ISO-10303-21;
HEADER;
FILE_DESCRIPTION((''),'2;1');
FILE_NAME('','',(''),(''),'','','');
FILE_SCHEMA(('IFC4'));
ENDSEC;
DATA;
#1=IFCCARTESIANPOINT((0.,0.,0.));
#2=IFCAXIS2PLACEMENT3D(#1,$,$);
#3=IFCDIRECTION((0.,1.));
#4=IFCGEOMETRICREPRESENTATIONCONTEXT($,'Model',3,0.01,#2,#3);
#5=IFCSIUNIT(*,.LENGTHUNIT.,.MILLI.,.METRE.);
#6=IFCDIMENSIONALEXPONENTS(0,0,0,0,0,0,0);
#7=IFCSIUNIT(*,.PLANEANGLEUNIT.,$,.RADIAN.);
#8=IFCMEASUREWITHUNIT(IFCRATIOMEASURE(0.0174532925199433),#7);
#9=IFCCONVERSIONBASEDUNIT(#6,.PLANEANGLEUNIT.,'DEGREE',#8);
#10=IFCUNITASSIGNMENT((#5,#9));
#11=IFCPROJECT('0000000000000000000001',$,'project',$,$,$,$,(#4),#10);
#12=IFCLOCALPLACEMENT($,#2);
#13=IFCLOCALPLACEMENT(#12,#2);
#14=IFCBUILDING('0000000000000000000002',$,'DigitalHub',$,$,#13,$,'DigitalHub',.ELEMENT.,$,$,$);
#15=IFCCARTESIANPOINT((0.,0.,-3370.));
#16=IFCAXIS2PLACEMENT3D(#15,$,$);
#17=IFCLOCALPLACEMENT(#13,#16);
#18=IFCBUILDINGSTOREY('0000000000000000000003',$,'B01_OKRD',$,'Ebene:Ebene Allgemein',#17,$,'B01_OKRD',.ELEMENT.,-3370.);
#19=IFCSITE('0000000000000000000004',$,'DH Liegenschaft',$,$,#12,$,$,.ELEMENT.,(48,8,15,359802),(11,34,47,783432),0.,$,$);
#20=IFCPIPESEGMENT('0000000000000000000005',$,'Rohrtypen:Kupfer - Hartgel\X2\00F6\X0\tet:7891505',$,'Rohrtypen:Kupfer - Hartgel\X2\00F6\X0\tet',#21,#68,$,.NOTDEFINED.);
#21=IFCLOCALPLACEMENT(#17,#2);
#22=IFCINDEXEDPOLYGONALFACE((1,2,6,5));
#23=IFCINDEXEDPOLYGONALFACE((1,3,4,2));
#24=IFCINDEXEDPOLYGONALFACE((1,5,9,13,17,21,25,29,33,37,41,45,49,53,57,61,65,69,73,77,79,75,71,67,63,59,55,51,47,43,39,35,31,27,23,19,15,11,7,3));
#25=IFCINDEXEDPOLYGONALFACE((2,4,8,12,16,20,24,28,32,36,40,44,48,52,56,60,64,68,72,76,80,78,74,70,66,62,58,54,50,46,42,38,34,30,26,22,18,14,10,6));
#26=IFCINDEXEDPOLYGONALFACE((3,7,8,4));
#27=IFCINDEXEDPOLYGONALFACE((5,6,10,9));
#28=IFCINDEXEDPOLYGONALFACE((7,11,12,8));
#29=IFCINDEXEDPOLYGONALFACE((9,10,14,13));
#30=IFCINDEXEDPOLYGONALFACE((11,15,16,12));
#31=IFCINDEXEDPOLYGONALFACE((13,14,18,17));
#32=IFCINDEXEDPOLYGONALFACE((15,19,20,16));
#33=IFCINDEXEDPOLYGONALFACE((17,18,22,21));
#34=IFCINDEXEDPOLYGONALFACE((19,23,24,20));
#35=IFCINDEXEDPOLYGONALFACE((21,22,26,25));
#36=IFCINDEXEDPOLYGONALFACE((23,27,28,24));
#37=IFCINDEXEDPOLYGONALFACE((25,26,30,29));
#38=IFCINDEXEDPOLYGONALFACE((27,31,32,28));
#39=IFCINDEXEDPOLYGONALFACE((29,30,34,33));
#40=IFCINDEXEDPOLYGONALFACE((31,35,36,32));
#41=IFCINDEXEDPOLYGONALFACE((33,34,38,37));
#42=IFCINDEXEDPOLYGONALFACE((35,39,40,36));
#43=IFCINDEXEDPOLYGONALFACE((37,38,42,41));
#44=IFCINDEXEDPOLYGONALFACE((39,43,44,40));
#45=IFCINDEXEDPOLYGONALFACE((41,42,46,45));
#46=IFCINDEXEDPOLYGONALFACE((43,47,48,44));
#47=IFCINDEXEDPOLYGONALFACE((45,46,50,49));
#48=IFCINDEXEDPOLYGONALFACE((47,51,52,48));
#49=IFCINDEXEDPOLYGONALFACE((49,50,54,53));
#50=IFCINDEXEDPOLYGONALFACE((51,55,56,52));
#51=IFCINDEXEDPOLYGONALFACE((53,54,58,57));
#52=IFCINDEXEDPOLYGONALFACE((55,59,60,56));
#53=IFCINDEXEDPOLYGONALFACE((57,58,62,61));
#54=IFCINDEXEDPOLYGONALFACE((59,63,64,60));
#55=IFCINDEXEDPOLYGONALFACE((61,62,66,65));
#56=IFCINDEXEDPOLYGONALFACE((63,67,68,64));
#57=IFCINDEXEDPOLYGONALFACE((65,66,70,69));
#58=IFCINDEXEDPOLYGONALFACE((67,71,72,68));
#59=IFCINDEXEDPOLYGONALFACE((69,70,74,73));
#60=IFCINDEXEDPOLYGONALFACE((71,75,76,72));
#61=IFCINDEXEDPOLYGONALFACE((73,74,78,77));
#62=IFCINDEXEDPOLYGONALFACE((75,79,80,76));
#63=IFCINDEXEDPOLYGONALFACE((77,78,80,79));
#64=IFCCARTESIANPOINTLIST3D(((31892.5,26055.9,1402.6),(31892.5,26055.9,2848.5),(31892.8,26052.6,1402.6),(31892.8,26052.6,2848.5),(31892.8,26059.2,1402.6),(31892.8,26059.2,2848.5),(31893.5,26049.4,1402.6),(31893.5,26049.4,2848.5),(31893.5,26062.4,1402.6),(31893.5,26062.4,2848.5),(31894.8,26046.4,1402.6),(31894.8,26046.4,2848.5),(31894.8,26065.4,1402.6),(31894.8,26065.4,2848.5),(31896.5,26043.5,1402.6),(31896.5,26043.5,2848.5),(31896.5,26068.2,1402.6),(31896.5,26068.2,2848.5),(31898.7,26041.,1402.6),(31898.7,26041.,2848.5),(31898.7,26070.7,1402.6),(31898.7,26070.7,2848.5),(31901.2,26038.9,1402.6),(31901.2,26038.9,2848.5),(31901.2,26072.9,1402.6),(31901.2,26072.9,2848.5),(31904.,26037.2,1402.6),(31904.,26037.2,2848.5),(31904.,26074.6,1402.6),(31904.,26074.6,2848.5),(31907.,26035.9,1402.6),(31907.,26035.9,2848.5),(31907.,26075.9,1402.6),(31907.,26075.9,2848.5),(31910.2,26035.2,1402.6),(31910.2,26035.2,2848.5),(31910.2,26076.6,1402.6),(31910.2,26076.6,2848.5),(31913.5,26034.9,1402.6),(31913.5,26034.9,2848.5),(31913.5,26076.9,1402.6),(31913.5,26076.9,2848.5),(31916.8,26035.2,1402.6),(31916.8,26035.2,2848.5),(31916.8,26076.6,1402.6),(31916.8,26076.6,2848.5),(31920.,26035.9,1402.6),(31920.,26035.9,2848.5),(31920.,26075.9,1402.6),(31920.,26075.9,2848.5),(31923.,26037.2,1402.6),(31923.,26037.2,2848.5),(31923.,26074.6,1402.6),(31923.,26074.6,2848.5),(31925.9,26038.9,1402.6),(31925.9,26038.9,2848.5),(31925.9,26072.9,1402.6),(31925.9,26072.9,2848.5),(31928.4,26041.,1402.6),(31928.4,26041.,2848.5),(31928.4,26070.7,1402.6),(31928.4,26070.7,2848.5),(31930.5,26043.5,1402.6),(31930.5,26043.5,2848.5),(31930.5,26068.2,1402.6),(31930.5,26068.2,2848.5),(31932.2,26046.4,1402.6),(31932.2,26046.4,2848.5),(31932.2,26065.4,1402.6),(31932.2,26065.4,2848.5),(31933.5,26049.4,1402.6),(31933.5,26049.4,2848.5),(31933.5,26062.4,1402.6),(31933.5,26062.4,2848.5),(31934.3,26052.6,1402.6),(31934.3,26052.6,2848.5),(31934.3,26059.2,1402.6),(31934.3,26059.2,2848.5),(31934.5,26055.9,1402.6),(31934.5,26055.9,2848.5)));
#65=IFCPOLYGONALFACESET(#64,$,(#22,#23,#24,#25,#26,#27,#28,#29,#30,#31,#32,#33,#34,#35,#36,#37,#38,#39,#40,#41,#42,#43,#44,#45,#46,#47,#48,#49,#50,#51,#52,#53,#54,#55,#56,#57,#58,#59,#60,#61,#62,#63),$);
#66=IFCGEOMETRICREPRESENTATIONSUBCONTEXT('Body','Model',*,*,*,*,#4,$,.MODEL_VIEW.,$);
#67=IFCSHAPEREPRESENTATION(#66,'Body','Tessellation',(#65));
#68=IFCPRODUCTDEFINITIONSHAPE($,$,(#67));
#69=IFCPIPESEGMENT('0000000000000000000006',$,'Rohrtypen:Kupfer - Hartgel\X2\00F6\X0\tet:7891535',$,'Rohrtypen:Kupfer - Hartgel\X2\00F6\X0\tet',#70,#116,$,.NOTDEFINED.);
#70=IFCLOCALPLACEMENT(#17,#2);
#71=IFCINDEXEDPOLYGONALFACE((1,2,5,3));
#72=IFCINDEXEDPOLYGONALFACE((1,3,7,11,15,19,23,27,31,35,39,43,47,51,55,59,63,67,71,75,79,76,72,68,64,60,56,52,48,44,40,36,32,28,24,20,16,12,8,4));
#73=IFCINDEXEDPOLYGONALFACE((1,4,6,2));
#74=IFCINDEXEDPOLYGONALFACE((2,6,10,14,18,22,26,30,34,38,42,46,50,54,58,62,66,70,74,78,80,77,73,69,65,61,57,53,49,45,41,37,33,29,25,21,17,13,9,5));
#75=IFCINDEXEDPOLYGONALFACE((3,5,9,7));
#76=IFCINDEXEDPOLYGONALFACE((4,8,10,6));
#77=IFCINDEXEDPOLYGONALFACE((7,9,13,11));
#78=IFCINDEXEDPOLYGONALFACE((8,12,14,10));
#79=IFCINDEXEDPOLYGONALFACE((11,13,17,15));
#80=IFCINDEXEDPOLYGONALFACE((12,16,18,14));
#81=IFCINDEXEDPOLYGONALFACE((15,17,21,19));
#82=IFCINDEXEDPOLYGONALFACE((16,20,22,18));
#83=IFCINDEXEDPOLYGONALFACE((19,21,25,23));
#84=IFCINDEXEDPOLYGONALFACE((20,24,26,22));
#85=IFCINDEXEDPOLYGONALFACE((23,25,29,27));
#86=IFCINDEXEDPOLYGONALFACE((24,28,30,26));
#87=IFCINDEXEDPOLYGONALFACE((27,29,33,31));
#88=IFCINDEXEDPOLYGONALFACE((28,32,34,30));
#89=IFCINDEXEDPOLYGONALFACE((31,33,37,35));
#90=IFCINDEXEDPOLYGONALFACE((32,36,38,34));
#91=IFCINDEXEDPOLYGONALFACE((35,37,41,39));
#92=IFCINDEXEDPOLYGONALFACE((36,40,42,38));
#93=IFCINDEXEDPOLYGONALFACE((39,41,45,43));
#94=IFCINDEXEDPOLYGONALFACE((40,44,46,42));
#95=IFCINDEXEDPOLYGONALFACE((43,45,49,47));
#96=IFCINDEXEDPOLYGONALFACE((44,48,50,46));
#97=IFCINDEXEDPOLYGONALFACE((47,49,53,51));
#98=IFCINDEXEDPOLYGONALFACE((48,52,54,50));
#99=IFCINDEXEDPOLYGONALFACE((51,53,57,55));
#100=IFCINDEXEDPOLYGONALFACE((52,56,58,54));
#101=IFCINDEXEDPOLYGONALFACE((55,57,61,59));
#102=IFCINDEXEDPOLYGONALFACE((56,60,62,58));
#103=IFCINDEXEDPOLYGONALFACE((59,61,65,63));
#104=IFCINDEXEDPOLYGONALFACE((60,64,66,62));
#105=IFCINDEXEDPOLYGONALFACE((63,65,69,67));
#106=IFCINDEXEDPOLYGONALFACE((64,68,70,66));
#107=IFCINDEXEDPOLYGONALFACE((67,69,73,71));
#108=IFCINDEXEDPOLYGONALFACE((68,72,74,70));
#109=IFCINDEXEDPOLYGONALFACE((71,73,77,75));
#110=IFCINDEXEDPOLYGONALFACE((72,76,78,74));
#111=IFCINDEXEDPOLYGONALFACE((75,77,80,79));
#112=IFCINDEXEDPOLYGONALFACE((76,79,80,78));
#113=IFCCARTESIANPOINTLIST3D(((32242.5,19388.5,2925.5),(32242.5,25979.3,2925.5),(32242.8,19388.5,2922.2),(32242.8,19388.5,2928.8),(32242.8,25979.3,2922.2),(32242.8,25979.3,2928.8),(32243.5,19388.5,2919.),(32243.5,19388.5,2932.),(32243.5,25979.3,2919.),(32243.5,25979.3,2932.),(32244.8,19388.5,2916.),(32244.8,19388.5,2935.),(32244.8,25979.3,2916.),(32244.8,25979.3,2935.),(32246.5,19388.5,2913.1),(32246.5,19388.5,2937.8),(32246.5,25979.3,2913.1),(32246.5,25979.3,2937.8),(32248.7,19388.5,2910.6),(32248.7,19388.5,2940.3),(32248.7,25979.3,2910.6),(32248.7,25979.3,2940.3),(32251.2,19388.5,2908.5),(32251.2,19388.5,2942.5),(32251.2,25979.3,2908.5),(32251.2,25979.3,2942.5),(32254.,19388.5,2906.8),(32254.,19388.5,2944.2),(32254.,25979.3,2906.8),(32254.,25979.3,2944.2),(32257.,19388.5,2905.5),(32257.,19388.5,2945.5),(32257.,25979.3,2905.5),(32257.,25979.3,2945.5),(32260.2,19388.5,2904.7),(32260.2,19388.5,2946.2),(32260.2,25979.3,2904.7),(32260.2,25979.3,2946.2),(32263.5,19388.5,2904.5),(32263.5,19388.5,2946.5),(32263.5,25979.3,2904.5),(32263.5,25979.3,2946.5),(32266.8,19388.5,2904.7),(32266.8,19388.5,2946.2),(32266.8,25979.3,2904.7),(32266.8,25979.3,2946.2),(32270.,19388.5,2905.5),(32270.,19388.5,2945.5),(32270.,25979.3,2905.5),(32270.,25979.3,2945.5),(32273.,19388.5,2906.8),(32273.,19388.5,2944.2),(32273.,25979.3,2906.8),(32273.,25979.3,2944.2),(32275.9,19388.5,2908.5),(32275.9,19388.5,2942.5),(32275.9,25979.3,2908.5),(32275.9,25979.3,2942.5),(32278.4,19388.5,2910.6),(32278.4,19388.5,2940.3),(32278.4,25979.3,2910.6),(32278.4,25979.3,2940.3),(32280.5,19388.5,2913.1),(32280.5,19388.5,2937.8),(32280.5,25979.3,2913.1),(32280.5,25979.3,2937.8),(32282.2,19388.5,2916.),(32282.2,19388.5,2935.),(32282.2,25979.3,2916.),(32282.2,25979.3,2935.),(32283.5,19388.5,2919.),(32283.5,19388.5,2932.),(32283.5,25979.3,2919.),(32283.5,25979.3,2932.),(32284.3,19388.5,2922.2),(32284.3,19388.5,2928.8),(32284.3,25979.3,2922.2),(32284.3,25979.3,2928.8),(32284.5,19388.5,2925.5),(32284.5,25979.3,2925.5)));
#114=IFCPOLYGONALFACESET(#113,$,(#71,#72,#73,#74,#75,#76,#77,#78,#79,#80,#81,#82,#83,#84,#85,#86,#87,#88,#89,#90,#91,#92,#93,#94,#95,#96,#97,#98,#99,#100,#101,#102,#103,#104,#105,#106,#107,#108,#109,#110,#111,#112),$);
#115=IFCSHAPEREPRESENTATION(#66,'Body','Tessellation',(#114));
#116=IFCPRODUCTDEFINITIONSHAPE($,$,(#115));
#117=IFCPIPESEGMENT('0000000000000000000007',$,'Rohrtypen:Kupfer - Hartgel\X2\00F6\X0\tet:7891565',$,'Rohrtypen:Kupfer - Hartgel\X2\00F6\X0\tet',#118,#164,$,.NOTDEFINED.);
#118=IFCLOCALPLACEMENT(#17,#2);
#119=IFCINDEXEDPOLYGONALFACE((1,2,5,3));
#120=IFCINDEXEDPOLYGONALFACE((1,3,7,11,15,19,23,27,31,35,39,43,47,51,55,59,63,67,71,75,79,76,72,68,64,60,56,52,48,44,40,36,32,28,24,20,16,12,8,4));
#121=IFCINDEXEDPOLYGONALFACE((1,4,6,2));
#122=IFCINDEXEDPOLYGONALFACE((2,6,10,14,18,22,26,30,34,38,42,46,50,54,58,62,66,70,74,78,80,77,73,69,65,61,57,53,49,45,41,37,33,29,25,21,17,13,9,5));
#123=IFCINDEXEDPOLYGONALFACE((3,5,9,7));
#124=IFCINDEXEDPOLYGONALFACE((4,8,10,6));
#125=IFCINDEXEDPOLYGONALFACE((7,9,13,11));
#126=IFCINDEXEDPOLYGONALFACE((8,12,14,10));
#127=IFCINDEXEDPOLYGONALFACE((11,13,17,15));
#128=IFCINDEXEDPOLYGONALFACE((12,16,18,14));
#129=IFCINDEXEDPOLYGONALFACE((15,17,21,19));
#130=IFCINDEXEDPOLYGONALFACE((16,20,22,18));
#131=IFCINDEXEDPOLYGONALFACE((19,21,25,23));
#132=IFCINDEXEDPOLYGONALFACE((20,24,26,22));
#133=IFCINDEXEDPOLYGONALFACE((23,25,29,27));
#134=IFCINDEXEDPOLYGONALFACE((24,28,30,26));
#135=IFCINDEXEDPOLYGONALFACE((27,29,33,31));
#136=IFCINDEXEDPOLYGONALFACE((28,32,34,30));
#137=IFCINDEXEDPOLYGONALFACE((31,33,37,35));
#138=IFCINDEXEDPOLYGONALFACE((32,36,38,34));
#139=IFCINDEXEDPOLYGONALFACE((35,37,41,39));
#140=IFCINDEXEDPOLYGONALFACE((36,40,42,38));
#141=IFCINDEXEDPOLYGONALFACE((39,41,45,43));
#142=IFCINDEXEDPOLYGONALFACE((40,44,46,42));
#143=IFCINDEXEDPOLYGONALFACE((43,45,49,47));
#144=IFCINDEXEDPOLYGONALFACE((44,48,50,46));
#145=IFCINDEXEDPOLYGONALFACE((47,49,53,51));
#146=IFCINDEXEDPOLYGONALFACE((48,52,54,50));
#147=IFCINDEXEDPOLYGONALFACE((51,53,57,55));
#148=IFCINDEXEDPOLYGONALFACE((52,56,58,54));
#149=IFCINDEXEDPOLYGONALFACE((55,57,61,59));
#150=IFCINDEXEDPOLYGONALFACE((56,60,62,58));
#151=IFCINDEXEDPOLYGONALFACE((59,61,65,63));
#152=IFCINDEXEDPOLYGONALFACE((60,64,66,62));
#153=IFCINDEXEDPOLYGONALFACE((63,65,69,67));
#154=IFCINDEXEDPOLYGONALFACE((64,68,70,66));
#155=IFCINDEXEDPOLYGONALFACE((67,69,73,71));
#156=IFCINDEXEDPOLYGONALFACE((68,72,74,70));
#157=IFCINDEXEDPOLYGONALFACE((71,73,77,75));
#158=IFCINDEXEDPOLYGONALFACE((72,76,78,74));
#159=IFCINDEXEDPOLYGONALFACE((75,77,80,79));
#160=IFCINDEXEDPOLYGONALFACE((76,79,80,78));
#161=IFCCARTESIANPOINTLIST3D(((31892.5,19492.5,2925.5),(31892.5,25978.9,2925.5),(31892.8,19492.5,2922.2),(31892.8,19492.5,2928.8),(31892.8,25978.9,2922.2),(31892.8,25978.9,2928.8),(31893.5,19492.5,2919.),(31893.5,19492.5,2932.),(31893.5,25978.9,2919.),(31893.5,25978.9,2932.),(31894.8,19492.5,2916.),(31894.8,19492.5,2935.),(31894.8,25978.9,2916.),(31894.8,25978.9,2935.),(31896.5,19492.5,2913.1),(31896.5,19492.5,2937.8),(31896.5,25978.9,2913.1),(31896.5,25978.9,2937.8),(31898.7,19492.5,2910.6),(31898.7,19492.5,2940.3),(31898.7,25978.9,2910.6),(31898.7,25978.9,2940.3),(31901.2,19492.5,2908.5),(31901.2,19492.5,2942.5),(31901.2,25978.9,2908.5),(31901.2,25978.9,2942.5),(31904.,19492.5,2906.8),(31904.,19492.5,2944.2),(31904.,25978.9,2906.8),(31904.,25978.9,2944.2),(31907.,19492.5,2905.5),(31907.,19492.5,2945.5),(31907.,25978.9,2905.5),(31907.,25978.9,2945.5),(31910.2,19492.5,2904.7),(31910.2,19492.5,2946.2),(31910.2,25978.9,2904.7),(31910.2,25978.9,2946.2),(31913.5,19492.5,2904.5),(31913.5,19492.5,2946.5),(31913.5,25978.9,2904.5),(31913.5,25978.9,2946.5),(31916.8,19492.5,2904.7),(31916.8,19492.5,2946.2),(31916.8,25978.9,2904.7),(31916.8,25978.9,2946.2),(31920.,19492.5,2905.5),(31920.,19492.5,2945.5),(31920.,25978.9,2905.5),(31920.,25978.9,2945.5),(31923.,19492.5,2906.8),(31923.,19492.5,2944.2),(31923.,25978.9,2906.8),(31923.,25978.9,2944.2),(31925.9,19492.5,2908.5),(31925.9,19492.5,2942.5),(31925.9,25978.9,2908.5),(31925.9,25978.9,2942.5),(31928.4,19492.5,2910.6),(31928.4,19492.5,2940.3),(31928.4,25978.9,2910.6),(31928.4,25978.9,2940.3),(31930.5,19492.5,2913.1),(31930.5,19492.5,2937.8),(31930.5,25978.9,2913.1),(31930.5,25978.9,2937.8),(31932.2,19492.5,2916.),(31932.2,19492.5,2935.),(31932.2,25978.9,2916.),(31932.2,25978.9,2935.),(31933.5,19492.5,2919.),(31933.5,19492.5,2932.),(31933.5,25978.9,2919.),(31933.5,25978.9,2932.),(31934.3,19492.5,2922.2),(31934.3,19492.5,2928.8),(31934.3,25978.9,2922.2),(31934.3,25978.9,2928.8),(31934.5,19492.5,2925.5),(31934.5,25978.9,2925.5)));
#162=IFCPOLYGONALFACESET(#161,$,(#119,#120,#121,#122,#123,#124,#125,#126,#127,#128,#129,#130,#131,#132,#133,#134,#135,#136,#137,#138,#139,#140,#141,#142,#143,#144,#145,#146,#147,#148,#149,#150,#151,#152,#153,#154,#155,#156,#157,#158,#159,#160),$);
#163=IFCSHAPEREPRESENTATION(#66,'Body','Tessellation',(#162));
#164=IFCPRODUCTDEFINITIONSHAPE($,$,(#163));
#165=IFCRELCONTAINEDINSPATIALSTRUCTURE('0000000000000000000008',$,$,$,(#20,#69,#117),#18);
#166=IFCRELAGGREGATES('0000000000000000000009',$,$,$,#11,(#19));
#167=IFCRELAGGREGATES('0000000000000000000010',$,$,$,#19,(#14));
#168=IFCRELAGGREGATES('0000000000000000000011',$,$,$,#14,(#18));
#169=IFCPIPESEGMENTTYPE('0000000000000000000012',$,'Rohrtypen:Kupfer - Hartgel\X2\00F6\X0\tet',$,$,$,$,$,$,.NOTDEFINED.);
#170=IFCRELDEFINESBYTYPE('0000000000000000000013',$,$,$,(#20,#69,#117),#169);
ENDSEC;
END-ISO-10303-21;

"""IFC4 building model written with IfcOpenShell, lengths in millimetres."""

from ifc_helpers import new_model, entity, si_unit, converted_unit, direction, frame, origin, place, context, subcontext, project, spatial, indexed_curve, outline, extrude, type_object, element, save


model = new_model("IFC4")

# Units and contexts
model_context = context("Model", 3, precision=0.01, world=origin(), true_north=direction((0.0, 1.0)))
body_context = subcontext(model_context, "Body", "Model", "MODEL_VIEW")
ifc_project = project(units=[si_unit("LENGTHUNIT", "METRE", prefix="MILLI"), converted_unit("PLANEANGLEUNIT", "DEGREE", entity("IfcRatioMeasure", 0.0174532925199433), si_unit("PLANEANGLEUNIT", "RADIAN"), dimensions=[0, 0, 0, 0, 0, 0, 0])], contexts=[model_context])

# Site, building, storey
site_placement = place(None, origin())
site = spatial("IfcSite", under=ifc_project, at=site_placement, Name="DH Liegenschaft", CompositionType="ELEMENT", RefLatitude=(48, 8, 15, 359802), RefLongitude=(11, 34, 47, 783432), RefElevation=0.0)
building_placement = place(site_placement, origin())
building = spatial("IfcBuilding", under=site, at=building_placement, Name="DigitalHub", LongName="DigitalHub", CompositionType="ELEMENT")
storey_placement = place(building_placement, frame((0.0, 0.0, -3370.0)))
storey = spatial("IfcBuildingStorey", under=building, at=storey_placement, Name="B01_OKRD", ObjectType="Ebene:Ebene Allgemein", LongName="B01_OKRD", CompositionType="ELEMENT", Elevation=-3370.0)

# Pipe segments
pipe_segment_type = type_object("IfcPipeSegmentType", Name="Rohrtypen:Kupfer - Hartgelötet", PredefinedType="NOTDEFINED")
pipe_segment_1_placement = place(storey_placement, frame((31890.9, 26033.3, 1402.6)))
element("IfcPipeSegment", 1, at=pipe_segment_1_placement, inside=storey, type_object=pipe_segment_type, Name="Rohrtypen:Kupfer - Hartgelötet:7891505", ObjectType="Rohrtypen:Kupfer - Hartgelötet", PredefinedType="NOTDEFINED", context=body_context, shape_type="SweptSolid", body=[
    extrude(outline(indexed_curve([(21.0, 0.0), (20.7, 3.3), (20.0, 6.5), (18.7, 9.5), (17.0, 12.3), (14.8, 14.8), (12.3, 17.0), (9.5, 18.7), (6.5, 20.0), (3.3, 20.7), (0.0, 21.0), (-3.3, 20.7), (-6.5, 20.0), (-9.5, 18.7), (-12.3, 17.0), (-14.8, 14.8), (-17.0, 12.3), (-18.7, 9.5), (-20.0, 6.5), (-20.7, 3.3), (-21.0, 0.0), (-20.7, -3.3), (-20.0, -6.5), (-18.7, -9.5), (-17.0, -12.3), (-14.8, -14.8), (-12.3, -17.0), (-9.5, -18.7), (-6.5, -20.0), (-3.3, -20.7), (0.0, -21.0), (3.3, -20.7), (6.5, -20.0), (9.5, -18.7), (12.3, -17.0), (14.8, -14.8), (17.0, -12.3), (18.7, -9.5), (20.0, -6.5), (20.7, -3.3), (21.0, 0.0)], self_intersect=False)), frame((22.6, 22.6, 0.0), z_axis=(0.0, 0.0, 1.0), x_axis=(-1.0, 0.0, 0.0)), (0.0, 0.0, 1.0), 1445.9),
])
pipe_segment_2_placement = place(storey_placement, frame((32240.9, 19388.5, 2902.9)))
element("IfcPipeSegment", 2, at=pipe_segment_2_placement, inside=storey, type_object=pipe_segment_type, Name="Rohrtypen:Kupfer - Hartgelötet:7891535", ObjectType="Rohrtypen:Kupfer - Hartgelötet", PredefinedType="NOTDEFINED", context=body_context, shape_type="SweptSolid", body=[
    extrude(outline(indexed_curve([(21.0, 0.0), (20.7, 3.3), (20.0, 6.5), (18.7, 9.5), (17.0, 12.3), (14.8, 14.8), (12.3, 17.0), (9.5, 18.7), (6.5, 20.0), (3.3, 20.7), (0.0, 21.0), (-3.3, 20.7), (-6.5, 20.0), (-9.5, 18.7), (-12.3, 17.0), (-14.8, 14.8), (-17.0, 12.3), (-18.7, 9.5), (-20.0, 6.5), (-20.7, 3.3), (-21.0, 0.0), (-20.7, -3.3), (-20.0, -6.5), (-18.7, -9.5), (-17.0, -12.3), (-14.8, -14.8), (-12.3, -17.0), (-9.5, -18.7), (-6.5, -20.0), (-3.3, -20.7), (0.0, -21.0), (3.3, -20.7), (6.5, -20.0), (9.5, -18.7), (12.3, -17.0), (14.8, -14.8), (17.0, -12.3), (18.7, -9.5), (20.0, -6.5), (20.7, -3.3), (21.0, 0.0)], self_intersect=False)), frame((22.6, 0.0, 22.6), z_axis=(0.0, 1.0, 0.0), x_axis=(-1.0, 0.0, 0.0)), (0.0, 0.0, 1.0), 6590.8),
])
pipe_segment_3_placement = place(storey_placement, frame((31890.9, 19492.5, 2902.9)))
element("IfcPipeSegment", 3, at=pipe_segment_3_placement, inside=storey, type_object=pipe_segment_type, Name="Rohrtypen:Kupfer - Hartgelötet:7891565", ObjectType="Rohrtypen:Kupfer - Hartgelötet", PredefinedType="NOTDEFINED", context=body_context, shape_type="SweptSolid", body=[
    extrude(outline(indexed_curve([(21.0, 0.0), (20.7, 3.3), (20.0, 6.5), (18.7, 9.5), (17.0, 12.3), (14.8, 14.8), (12.3, 17.0), (9.5, 18.7), (6.5, 20.0), (3.3, 20.7), (0.0, 21.0), (-3.3, 20.7), (-6.5, 20.0), (-9.5, 18.7), (-12.3, 17.0), (-14.8, 14.8), (-17.0, 12.3), (-18.7, 9.5), (-20.0, 6.5), (-20.7, 3.3), (-21.0, 0.0), (-20.7, -3.3), (-20.0, -6.5), (-18.7, -9.5), (-17.0, -12.3), (-14.8, -14.8), (-12.3, -17.0), (-9.5, -18.7), (-6.5, -20.0), (-3.3, -20.7), (0.0, -21.0), (3.3, -20.7), (6.5, -20.0), (9.5, -18.7), (12.3, -17.0), (14.8, -14.8), (17.0, -12.3), (18.7, -9.5), (20.0, -6.5), (20.7, -3.3), (21.0, 0.0)], self_intersect=False)), frame((22.6, 0.0, 22.6), z_axis=(0.0, 1.0, 0.0), x_axis=(-1.0, 0.0, 0.0)), (0.0, 0.0, 1.0), 6486.4),
])

save(model, "model.ifc")
